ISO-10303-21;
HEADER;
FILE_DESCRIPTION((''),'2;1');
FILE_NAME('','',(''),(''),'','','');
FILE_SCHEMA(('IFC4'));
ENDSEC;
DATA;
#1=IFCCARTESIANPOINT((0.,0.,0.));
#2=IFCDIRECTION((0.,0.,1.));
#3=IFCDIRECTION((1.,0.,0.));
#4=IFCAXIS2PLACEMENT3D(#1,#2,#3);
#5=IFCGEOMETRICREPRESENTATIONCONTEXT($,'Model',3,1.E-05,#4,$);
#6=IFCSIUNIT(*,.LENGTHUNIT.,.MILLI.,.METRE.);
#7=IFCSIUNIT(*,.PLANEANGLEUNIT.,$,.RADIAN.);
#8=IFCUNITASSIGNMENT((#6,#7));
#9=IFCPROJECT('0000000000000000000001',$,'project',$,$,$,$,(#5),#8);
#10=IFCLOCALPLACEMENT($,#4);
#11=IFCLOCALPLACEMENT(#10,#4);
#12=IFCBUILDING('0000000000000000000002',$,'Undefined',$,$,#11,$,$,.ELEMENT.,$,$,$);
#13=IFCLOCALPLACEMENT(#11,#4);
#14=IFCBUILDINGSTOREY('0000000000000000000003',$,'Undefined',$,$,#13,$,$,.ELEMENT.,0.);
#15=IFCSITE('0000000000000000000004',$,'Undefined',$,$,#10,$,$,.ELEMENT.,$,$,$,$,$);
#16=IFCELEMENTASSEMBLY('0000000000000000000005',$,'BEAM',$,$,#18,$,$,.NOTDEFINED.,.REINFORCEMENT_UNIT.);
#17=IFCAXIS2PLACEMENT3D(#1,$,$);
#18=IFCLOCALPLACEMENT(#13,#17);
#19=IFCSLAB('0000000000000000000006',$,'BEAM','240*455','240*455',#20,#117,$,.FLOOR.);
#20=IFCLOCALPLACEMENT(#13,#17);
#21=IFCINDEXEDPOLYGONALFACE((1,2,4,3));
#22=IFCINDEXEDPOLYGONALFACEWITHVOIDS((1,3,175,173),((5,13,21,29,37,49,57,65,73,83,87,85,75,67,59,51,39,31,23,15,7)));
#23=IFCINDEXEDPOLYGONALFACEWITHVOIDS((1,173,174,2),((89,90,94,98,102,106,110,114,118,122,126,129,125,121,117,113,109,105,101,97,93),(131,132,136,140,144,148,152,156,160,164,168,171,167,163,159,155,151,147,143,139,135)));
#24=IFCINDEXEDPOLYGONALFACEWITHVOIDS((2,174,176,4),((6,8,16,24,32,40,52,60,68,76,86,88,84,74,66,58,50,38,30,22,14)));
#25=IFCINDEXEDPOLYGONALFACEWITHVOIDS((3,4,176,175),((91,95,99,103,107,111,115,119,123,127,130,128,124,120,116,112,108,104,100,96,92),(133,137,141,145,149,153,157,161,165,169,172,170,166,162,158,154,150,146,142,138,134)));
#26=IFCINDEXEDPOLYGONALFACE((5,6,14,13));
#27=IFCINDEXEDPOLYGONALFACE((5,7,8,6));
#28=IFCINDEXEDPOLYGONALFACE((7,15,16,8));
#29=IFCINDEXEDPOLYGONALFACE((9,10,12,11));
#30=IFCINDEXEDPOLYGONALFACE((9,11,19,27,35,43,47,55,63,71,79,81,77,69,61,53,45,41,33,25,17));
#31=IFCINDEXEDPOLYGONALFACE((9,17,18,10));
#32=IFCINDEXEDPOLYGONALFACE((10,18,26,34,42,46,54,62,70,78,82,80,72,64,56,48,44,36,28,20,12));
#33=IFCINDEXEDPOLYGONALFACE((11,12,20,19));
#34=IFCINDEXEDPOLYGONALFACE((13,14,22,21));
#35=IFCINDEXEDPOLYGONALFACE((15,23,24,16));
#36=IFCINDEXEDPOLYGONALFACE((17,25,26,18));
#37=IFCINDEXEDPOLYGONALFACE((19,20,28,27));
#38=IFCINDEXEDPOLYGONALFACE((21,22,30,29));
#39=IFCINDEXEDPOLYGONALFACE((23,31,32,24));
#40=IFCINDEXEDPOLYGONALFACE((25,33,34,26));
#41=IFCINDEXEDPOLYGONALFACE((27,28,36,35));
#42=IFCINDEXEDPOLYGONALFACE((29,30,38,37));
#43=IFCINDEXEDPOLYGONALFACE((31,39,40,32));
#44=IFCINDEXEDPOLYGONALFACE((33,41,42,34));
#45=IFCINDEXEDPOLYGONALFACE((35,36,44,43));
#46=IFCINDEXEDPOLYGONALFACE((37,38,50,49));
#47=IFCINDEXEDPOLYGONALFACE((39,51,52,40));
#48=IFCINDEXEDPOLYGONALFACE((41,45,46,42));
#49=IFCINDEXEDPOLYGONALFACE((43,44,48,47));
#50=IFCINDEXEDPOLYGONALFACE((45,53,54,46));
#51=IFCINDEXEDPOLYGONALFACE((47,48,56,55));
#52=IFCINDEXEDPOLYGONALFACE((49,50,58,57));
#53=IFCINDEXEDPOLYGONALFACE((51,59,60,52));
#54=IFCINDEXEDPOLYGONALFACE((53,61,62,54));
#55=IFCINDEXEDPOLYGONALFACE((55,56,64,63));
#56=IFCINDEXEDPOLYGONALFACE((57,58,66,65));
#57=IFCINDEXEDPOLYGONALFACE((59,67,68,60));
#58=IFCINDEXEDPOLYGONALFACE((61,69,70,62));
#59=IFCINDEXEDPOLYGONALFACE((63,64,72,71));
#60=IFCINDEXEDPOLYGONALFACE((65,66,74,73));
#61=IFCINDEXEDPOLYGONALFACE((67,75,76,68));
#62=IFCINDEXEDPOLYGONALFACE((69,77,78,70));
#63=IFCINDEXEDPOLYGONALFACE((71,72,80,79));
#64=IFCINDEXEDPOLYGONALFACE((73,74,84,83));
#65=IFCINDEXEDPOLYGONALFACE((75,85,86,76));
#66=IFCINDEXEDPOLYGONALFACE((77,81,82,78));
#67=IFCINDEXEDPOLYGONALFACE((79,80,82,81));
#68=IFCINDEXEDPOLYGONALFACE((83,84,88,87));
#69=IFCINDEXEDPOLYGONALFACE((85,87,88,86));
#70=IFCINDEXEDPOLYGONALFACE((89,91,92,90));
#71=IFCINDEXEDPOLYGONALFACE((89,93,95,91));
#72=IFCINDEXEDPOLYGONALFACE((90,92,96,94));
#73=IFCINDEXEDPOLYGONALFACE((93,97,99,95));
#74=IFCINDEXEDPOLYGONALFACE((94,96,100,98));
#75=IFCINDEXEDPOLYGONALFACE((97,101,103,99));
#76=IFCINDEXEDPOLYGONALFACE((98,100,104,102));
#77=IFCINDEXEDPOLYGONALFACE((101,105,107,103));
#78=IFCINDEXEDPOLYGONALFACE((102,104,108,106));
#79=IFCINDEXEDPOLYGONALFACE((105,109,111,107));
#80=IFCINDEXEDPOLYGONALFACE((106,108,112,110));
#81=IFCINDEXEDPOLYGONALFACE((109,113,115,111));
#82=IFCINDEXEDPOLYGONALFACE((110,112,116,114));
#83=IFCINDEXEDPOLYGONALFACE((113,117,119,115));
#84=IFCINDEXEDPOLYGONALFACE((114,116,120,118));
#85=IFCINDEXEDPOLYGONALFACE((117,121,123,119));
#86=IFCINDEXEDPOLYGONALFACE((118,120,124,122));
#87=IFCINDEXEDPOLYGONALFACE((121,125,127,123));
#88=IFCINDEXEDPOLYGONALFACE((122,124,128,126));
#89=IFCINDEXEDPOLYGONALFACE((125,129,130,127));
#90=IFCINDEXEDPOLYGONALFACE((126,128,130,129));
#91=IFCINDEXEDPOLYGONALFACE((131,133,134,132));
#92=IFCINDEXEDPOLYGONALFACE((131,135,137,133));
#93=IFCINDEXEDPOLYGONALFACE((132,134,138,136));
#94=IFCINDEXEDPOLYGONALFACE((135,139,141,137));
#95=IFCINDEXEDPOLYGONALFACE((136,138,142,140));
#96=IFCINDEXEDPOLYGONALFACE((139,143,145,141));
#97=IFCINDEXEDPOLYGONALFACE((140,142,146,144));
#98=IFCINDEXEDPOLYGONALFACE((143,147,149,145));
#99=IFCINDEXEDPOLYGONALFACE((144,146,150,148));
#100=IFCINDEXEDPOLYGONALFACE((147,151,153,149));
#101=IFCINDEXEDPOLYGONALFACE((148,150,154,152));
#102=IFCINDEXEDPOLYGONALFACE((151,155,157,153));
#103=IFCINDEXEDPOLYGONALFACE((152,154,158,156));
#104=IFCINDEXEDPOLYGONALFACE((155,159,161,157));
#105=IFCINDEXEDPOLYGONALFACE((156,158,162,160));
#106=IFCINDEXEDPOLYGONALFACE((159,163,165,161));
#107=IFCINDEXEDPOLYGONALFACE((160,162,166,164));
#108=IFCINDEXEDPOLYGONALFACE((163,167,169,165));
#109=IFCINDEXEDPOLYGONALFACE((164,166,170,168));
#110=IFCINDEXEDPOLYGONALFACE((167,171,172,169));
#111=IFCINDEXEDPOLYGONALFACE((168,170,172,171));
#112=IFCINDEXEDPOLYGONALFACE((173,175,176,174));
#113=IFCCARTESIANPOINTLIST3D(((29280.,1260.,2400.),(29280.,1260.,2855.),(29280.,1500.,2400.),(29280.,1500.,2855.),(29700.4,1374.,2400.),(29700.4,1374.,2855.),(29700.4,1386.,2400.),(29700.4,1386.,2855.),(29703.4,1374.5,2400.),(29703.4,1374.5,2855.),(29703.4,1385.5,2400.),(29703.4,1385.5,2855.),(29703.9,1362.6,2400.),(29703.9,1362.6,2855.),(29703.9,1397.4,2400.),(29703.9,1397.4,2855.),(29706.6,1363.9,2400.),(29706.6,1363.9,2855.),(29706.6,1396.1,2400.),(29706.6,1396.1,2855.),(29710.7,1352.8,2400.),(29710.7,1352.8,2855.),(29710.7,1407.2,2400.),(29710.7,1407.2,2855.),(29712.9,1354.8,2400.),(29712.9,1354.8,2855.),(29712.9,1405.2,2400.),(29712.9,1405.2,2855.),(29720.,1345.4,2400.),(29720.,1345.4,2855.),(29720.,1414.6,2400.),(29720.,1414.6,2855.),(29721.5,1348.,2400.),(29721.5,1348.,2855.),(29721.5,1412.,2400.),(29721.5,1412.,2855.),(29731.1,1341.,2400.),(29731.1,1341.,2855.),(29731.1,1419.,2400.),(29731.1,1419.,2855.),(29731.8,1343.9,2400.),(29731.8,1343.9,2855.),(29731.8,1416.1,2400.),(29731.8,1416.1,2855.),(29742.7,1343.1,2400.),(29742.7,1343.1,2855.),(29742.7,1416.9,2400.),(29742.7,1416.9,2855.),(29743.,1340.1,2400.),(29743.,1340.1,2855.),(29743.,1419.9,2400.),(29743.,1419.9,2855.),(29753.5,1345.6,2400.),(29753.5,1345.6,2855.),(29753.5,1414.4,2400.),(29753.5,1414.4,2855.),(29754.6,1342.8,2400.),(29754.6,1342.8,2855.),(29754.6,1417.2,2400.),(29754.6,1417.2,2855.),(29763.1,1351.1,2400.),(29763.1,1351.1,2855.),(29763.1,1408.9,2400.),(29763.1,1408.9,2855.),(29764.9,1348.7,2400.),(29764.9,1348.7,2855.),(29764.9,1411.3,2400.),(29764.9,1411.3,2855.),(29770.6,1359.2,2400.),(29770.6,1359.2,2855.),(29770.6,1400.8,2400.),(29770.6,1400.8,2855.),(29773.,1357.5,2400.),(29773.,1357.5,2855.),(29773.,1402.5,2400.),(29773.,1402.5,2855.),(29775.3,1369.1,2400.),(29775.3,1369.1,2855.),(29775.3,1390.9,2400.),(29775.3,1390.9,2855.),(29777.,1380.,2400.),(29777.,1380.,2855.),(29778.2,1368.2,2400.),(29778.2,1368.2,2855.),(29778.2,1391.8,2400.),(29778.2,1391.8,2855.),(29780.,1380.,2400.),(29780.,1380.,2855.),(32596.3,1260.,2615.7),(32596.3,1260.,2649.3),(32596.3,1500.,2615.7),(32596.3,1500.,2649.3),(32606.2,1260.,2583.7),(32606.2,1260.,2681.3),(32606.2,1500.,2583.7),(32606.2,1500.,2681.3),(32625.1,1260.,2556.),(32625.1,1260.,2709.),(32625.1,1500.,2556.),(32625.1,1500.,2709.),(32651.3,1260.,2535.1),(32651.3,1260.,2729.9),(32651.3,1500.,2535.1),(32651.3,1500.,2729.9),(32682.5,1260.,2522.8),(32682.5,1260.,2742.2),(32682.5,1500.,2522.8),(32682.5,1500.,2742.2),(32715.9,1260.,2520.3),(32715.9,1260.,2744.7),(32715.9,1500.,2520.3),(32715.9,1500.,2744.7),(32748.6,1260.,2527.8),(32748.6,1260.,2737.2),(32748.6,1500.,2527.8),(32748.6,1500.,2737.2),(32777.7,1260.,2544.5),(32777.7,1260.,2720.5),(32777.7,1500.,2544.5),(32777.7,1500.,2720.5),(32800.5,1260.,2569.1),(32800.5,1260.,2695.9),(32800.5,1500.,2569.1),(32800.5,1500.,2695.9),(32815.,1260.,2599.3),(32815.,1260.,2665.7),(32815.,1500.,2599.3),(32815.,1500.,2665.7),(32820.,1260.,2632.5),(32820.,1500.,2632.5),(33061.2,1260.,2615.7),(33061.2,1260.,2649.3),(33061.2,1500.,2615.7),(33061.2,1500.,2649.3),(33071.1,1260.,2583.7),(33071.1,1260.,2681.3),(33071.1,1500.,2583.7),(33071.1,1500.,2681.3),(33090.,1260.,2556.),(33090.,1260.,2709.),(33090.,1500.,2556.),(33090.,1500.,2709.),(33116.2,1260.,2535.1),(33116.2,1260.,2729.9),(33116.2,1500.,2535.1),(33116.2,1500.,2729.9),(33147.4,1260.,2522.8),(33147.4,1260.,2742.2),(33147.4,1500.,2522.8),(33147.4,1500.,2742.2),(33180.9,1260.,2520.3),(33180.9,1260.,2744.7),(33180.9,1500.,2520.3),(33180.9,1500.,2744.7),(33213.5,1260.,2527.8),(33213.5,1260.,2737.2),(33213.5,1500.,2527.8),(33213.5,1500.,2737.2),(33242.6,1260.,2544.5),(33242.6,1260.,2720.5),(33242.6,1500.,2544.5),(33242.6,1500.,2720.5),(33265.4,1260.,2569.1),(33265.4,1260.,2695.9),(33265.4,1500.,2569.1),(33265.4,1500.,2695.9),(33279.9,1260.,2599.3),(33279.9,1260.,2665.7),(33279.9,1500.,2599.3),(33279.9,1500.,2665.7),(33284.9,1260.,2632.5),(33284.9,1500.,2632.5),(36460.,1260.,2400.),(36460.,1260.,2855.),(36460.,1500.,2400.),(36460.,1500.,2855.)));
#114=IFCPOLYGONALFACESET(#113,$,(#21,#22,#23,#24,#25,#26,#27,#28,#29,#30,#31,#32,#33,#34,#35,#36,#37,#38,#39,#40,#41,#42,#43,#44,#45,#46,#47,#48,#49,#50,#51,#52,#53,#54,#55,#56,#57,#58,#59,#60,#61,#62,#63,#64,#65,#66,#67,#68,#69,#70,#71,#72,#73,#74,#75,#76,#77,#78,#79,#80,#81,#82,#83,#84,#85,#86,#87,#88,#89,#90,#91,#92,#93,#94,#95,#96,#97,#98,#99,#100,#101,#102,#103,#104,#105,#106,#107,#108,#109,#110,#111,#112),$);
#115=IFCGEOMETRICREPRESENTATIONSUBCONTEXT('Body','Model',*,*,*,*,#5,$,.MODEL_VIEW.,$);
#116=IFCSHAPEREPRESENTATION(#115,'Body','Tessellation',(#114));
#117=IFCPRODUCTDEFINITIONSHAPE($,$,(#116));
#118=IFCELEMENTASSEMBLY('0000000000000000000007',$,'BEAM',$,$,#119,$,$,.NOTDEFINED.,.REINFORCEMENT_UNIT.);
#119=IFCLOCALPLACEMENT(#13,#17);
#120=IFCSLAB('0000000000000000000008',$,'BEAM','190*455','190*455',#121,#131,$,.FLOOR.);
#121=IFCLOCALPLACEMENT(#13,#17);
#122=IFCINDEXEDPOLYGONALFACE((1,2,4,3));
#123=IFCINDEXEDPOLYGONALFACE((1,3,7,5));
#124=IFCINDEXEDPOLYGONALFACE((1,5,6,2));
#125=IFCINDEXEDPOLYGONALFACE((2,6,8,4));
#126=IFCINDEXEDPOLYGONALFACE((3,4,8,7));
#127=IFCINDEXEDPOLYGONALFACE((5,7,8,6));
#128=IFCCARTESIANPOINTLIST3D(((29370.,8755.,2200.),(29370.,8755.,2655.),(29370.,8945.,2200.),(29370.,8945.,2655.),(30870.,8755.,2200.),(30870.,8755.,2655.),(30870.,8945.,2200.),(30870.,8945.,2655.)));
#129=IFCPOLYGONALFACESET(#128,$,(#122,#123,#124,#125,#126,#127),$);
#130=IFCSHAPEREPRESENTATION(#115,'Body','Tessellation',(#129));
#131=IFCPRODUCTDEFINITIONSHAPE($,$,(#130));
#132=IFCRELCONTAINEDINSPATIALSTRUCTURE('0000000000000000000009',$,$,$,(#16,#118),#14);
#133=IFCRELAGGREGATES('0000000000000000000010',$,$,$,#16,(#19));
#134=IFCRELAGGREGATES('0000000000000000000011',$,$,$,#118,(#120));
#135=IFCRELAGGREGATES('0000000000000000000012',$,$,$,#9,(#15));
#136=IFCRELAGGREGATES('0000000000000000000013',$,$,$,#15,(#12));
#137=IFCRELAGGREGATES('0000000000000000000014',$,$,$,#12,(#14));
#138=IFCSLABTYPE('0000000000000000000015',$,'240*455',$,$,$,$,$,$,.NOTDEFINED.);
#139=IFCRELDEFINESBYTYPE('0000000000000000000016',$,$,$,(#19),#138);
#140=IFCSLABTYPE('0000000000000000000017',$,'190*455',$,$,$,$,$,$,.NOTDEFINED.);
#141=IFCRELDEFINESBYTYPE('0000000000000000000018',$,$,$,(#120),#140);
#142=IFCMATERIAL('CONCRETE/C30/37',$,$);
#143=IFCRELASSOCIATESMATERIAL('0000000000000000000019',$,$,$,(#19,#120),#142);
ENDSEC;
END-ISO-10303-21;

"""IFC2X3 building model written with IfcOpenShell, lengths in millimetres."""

from ifc_helpers import new_model, si_unit, frame, origin_with_axes, origin_2d_with_axis, place, context, subcontext, project, spatial, polyline, circle, hollow_circle, outline, extrude, boolean, material, type_object, element, aggregate, save


model = new_model("IFC2X3")

# Units and contexts
model_context = context("Model", 3, precision=1e-05, world=origin_with_axes())
body_context = subcontext(model_context, "Body", "Model", "MODEL_VIEW")
ifc_project = project(units=[si_unit("LENGTHUNIT", "METRE", prefix="MILLI"), si_unit("PLANEANGLEUNIT", "RADIAN")], contexts=[model_context])

# Site, building, storey
site_placement = place(None, origin_with_axes())
site = spatial("IfcSite", under=ifc_project, at=site_placement, Name="Undefined", CompositionType="ELEMENT")
building_placement = place(site_placement, origin_with_axes())
building = spatial("IfcBuilding", under=site, at=building_placement, Name="Undefined", CompositionType="ELEMENT")
storey_placement = place(building_placement, origin_with_axes())
storey = spatial("IfcBuildingStorey", under=building, at=storey_placement, Name="Undefined", CompositionType="ELEMENT", Elevation=0.0)

# Element assembly
assembly_1_placement = place(storey_placement, origin_with_axes())
assembly_1 = element("IfcElementAssembly", 1, at=assembly_1_placement, inside=storey, Name="BEAM", AssemblyPlace="NOTDEFINED", PredefinedType="REINFORCEMENT_UNIT")

# Slab
ifc_material_1 = material(Name="CONCRETE/C30/37")
slab_type_1 = type_object("IfcSlabType", Name="240*455", PredefinedType="NOTDEFINED")
slab_1_placement = place(assembly_1_placement, frame((29280.0, 1380.0, 2400.0), z_axis=(0.0, 1.0, 0.0), x_axis=(0.0, 0.0, 1.0)))
slab_1 = element("IfcSlab", 2, at=slab_1_placement, type_object=slab_type_1, material=ifc_material_1, Name="BEAM", Description="240*455", ObjectType="240*455", PredefinedType="FLOOR", context=body_context, shape_type="CSG", body=[
    boolean("DIFFERENCE", boolean("DIFFERENCE", boolean("DIFFERENCE", extrude(outline(polyline([(0.0, 0.0), (455.0, 0.0), (455.0, 7180.0), (0.0, 7180.0), (0.0, 0.0)])), frame((0.0, 0.0, -120.0), z_axis=(0.0, 0.0, 1.0), x_axis=(1.0, 0.0, 0.0)), (0.0, 0.0, 1.0), 240.0), extrude(hollow_circle(Radius=40.0, WallThickness=3.0, at=origin_2d_with_axis()), frame((455.0, 460.0, 0.0), z_axis=(-1.0, 0.0, 0.0), x_axis=(0.0, 1.0, 0.0)), (0.0, 0.0, 1.0), 455.0)), extrude(circle(Radius=112.5, at=origin_2d_with_axis()), frame((232.5, 3892.5, 125.0), z_axis=(0.0, 0.0, -1.0), x_axis=(0.0, 1.0, 0.0)), (0.0, 0.0, 1.0), 250.0)), extrude(circle(Radius=112.5, at=origin_2d_with_axis()), frame((232.5, 3427.6, 125.0), z_axis=(0.0, 0.0, -1.0), x_axis=(0.0, 1.0, 0.0)), (0.0, 0.0, 1.0), 250.0)),
])

# Element assembly, slab
assembly_2_placement = place(storey_placement, origin_with_axes())
assembly_2 = element("IfcElementAssembly", 3, at=assembly_2_placement, inside=storey, Name="BEAM", AssemblyPlace="NOTDEFINED", PredefinedType="REINFORCEMENT_UNIT")
slab_type_2 = type_object("IfcSlabType", Name="190*455", PredefinedType="NOTDEFINED")
slab_2_placement = place(assembly_2_placement, frame((29370.0, 8850.0, 2200.0), z_axis=(0.0, 1.0, 0.0), x_axis=(0.0, 0.0, 1.0)))
slab_2 = element("IfcSlab", 4, at=slab_2_placement, type_object=slab_type_2, material=ifc_material_1, Name="BEAM", Description="190*455", ObjectType="190*455", PredefinedType="FLOOR", context=body_context, shape_type="SweptSolid", body=[
    extrude(outline(polyline([(0.0, 0.0), (455.0, 0.0), (455.0, 1500.0), (0.0, 1500.0), (0.0, 0.0)])), frame((0.0, 0.0, -95.0), z_axis=(0.0, 0.0, 1.0), x_axis=(1.0, 0.0, 0.0)), (0.0, 0.0, 1.0), 190.0),
])

aggregate(assembly_1, [slab_1])
aggregate(assembly_2, [slab_2])

save(model, "model.ifc")
